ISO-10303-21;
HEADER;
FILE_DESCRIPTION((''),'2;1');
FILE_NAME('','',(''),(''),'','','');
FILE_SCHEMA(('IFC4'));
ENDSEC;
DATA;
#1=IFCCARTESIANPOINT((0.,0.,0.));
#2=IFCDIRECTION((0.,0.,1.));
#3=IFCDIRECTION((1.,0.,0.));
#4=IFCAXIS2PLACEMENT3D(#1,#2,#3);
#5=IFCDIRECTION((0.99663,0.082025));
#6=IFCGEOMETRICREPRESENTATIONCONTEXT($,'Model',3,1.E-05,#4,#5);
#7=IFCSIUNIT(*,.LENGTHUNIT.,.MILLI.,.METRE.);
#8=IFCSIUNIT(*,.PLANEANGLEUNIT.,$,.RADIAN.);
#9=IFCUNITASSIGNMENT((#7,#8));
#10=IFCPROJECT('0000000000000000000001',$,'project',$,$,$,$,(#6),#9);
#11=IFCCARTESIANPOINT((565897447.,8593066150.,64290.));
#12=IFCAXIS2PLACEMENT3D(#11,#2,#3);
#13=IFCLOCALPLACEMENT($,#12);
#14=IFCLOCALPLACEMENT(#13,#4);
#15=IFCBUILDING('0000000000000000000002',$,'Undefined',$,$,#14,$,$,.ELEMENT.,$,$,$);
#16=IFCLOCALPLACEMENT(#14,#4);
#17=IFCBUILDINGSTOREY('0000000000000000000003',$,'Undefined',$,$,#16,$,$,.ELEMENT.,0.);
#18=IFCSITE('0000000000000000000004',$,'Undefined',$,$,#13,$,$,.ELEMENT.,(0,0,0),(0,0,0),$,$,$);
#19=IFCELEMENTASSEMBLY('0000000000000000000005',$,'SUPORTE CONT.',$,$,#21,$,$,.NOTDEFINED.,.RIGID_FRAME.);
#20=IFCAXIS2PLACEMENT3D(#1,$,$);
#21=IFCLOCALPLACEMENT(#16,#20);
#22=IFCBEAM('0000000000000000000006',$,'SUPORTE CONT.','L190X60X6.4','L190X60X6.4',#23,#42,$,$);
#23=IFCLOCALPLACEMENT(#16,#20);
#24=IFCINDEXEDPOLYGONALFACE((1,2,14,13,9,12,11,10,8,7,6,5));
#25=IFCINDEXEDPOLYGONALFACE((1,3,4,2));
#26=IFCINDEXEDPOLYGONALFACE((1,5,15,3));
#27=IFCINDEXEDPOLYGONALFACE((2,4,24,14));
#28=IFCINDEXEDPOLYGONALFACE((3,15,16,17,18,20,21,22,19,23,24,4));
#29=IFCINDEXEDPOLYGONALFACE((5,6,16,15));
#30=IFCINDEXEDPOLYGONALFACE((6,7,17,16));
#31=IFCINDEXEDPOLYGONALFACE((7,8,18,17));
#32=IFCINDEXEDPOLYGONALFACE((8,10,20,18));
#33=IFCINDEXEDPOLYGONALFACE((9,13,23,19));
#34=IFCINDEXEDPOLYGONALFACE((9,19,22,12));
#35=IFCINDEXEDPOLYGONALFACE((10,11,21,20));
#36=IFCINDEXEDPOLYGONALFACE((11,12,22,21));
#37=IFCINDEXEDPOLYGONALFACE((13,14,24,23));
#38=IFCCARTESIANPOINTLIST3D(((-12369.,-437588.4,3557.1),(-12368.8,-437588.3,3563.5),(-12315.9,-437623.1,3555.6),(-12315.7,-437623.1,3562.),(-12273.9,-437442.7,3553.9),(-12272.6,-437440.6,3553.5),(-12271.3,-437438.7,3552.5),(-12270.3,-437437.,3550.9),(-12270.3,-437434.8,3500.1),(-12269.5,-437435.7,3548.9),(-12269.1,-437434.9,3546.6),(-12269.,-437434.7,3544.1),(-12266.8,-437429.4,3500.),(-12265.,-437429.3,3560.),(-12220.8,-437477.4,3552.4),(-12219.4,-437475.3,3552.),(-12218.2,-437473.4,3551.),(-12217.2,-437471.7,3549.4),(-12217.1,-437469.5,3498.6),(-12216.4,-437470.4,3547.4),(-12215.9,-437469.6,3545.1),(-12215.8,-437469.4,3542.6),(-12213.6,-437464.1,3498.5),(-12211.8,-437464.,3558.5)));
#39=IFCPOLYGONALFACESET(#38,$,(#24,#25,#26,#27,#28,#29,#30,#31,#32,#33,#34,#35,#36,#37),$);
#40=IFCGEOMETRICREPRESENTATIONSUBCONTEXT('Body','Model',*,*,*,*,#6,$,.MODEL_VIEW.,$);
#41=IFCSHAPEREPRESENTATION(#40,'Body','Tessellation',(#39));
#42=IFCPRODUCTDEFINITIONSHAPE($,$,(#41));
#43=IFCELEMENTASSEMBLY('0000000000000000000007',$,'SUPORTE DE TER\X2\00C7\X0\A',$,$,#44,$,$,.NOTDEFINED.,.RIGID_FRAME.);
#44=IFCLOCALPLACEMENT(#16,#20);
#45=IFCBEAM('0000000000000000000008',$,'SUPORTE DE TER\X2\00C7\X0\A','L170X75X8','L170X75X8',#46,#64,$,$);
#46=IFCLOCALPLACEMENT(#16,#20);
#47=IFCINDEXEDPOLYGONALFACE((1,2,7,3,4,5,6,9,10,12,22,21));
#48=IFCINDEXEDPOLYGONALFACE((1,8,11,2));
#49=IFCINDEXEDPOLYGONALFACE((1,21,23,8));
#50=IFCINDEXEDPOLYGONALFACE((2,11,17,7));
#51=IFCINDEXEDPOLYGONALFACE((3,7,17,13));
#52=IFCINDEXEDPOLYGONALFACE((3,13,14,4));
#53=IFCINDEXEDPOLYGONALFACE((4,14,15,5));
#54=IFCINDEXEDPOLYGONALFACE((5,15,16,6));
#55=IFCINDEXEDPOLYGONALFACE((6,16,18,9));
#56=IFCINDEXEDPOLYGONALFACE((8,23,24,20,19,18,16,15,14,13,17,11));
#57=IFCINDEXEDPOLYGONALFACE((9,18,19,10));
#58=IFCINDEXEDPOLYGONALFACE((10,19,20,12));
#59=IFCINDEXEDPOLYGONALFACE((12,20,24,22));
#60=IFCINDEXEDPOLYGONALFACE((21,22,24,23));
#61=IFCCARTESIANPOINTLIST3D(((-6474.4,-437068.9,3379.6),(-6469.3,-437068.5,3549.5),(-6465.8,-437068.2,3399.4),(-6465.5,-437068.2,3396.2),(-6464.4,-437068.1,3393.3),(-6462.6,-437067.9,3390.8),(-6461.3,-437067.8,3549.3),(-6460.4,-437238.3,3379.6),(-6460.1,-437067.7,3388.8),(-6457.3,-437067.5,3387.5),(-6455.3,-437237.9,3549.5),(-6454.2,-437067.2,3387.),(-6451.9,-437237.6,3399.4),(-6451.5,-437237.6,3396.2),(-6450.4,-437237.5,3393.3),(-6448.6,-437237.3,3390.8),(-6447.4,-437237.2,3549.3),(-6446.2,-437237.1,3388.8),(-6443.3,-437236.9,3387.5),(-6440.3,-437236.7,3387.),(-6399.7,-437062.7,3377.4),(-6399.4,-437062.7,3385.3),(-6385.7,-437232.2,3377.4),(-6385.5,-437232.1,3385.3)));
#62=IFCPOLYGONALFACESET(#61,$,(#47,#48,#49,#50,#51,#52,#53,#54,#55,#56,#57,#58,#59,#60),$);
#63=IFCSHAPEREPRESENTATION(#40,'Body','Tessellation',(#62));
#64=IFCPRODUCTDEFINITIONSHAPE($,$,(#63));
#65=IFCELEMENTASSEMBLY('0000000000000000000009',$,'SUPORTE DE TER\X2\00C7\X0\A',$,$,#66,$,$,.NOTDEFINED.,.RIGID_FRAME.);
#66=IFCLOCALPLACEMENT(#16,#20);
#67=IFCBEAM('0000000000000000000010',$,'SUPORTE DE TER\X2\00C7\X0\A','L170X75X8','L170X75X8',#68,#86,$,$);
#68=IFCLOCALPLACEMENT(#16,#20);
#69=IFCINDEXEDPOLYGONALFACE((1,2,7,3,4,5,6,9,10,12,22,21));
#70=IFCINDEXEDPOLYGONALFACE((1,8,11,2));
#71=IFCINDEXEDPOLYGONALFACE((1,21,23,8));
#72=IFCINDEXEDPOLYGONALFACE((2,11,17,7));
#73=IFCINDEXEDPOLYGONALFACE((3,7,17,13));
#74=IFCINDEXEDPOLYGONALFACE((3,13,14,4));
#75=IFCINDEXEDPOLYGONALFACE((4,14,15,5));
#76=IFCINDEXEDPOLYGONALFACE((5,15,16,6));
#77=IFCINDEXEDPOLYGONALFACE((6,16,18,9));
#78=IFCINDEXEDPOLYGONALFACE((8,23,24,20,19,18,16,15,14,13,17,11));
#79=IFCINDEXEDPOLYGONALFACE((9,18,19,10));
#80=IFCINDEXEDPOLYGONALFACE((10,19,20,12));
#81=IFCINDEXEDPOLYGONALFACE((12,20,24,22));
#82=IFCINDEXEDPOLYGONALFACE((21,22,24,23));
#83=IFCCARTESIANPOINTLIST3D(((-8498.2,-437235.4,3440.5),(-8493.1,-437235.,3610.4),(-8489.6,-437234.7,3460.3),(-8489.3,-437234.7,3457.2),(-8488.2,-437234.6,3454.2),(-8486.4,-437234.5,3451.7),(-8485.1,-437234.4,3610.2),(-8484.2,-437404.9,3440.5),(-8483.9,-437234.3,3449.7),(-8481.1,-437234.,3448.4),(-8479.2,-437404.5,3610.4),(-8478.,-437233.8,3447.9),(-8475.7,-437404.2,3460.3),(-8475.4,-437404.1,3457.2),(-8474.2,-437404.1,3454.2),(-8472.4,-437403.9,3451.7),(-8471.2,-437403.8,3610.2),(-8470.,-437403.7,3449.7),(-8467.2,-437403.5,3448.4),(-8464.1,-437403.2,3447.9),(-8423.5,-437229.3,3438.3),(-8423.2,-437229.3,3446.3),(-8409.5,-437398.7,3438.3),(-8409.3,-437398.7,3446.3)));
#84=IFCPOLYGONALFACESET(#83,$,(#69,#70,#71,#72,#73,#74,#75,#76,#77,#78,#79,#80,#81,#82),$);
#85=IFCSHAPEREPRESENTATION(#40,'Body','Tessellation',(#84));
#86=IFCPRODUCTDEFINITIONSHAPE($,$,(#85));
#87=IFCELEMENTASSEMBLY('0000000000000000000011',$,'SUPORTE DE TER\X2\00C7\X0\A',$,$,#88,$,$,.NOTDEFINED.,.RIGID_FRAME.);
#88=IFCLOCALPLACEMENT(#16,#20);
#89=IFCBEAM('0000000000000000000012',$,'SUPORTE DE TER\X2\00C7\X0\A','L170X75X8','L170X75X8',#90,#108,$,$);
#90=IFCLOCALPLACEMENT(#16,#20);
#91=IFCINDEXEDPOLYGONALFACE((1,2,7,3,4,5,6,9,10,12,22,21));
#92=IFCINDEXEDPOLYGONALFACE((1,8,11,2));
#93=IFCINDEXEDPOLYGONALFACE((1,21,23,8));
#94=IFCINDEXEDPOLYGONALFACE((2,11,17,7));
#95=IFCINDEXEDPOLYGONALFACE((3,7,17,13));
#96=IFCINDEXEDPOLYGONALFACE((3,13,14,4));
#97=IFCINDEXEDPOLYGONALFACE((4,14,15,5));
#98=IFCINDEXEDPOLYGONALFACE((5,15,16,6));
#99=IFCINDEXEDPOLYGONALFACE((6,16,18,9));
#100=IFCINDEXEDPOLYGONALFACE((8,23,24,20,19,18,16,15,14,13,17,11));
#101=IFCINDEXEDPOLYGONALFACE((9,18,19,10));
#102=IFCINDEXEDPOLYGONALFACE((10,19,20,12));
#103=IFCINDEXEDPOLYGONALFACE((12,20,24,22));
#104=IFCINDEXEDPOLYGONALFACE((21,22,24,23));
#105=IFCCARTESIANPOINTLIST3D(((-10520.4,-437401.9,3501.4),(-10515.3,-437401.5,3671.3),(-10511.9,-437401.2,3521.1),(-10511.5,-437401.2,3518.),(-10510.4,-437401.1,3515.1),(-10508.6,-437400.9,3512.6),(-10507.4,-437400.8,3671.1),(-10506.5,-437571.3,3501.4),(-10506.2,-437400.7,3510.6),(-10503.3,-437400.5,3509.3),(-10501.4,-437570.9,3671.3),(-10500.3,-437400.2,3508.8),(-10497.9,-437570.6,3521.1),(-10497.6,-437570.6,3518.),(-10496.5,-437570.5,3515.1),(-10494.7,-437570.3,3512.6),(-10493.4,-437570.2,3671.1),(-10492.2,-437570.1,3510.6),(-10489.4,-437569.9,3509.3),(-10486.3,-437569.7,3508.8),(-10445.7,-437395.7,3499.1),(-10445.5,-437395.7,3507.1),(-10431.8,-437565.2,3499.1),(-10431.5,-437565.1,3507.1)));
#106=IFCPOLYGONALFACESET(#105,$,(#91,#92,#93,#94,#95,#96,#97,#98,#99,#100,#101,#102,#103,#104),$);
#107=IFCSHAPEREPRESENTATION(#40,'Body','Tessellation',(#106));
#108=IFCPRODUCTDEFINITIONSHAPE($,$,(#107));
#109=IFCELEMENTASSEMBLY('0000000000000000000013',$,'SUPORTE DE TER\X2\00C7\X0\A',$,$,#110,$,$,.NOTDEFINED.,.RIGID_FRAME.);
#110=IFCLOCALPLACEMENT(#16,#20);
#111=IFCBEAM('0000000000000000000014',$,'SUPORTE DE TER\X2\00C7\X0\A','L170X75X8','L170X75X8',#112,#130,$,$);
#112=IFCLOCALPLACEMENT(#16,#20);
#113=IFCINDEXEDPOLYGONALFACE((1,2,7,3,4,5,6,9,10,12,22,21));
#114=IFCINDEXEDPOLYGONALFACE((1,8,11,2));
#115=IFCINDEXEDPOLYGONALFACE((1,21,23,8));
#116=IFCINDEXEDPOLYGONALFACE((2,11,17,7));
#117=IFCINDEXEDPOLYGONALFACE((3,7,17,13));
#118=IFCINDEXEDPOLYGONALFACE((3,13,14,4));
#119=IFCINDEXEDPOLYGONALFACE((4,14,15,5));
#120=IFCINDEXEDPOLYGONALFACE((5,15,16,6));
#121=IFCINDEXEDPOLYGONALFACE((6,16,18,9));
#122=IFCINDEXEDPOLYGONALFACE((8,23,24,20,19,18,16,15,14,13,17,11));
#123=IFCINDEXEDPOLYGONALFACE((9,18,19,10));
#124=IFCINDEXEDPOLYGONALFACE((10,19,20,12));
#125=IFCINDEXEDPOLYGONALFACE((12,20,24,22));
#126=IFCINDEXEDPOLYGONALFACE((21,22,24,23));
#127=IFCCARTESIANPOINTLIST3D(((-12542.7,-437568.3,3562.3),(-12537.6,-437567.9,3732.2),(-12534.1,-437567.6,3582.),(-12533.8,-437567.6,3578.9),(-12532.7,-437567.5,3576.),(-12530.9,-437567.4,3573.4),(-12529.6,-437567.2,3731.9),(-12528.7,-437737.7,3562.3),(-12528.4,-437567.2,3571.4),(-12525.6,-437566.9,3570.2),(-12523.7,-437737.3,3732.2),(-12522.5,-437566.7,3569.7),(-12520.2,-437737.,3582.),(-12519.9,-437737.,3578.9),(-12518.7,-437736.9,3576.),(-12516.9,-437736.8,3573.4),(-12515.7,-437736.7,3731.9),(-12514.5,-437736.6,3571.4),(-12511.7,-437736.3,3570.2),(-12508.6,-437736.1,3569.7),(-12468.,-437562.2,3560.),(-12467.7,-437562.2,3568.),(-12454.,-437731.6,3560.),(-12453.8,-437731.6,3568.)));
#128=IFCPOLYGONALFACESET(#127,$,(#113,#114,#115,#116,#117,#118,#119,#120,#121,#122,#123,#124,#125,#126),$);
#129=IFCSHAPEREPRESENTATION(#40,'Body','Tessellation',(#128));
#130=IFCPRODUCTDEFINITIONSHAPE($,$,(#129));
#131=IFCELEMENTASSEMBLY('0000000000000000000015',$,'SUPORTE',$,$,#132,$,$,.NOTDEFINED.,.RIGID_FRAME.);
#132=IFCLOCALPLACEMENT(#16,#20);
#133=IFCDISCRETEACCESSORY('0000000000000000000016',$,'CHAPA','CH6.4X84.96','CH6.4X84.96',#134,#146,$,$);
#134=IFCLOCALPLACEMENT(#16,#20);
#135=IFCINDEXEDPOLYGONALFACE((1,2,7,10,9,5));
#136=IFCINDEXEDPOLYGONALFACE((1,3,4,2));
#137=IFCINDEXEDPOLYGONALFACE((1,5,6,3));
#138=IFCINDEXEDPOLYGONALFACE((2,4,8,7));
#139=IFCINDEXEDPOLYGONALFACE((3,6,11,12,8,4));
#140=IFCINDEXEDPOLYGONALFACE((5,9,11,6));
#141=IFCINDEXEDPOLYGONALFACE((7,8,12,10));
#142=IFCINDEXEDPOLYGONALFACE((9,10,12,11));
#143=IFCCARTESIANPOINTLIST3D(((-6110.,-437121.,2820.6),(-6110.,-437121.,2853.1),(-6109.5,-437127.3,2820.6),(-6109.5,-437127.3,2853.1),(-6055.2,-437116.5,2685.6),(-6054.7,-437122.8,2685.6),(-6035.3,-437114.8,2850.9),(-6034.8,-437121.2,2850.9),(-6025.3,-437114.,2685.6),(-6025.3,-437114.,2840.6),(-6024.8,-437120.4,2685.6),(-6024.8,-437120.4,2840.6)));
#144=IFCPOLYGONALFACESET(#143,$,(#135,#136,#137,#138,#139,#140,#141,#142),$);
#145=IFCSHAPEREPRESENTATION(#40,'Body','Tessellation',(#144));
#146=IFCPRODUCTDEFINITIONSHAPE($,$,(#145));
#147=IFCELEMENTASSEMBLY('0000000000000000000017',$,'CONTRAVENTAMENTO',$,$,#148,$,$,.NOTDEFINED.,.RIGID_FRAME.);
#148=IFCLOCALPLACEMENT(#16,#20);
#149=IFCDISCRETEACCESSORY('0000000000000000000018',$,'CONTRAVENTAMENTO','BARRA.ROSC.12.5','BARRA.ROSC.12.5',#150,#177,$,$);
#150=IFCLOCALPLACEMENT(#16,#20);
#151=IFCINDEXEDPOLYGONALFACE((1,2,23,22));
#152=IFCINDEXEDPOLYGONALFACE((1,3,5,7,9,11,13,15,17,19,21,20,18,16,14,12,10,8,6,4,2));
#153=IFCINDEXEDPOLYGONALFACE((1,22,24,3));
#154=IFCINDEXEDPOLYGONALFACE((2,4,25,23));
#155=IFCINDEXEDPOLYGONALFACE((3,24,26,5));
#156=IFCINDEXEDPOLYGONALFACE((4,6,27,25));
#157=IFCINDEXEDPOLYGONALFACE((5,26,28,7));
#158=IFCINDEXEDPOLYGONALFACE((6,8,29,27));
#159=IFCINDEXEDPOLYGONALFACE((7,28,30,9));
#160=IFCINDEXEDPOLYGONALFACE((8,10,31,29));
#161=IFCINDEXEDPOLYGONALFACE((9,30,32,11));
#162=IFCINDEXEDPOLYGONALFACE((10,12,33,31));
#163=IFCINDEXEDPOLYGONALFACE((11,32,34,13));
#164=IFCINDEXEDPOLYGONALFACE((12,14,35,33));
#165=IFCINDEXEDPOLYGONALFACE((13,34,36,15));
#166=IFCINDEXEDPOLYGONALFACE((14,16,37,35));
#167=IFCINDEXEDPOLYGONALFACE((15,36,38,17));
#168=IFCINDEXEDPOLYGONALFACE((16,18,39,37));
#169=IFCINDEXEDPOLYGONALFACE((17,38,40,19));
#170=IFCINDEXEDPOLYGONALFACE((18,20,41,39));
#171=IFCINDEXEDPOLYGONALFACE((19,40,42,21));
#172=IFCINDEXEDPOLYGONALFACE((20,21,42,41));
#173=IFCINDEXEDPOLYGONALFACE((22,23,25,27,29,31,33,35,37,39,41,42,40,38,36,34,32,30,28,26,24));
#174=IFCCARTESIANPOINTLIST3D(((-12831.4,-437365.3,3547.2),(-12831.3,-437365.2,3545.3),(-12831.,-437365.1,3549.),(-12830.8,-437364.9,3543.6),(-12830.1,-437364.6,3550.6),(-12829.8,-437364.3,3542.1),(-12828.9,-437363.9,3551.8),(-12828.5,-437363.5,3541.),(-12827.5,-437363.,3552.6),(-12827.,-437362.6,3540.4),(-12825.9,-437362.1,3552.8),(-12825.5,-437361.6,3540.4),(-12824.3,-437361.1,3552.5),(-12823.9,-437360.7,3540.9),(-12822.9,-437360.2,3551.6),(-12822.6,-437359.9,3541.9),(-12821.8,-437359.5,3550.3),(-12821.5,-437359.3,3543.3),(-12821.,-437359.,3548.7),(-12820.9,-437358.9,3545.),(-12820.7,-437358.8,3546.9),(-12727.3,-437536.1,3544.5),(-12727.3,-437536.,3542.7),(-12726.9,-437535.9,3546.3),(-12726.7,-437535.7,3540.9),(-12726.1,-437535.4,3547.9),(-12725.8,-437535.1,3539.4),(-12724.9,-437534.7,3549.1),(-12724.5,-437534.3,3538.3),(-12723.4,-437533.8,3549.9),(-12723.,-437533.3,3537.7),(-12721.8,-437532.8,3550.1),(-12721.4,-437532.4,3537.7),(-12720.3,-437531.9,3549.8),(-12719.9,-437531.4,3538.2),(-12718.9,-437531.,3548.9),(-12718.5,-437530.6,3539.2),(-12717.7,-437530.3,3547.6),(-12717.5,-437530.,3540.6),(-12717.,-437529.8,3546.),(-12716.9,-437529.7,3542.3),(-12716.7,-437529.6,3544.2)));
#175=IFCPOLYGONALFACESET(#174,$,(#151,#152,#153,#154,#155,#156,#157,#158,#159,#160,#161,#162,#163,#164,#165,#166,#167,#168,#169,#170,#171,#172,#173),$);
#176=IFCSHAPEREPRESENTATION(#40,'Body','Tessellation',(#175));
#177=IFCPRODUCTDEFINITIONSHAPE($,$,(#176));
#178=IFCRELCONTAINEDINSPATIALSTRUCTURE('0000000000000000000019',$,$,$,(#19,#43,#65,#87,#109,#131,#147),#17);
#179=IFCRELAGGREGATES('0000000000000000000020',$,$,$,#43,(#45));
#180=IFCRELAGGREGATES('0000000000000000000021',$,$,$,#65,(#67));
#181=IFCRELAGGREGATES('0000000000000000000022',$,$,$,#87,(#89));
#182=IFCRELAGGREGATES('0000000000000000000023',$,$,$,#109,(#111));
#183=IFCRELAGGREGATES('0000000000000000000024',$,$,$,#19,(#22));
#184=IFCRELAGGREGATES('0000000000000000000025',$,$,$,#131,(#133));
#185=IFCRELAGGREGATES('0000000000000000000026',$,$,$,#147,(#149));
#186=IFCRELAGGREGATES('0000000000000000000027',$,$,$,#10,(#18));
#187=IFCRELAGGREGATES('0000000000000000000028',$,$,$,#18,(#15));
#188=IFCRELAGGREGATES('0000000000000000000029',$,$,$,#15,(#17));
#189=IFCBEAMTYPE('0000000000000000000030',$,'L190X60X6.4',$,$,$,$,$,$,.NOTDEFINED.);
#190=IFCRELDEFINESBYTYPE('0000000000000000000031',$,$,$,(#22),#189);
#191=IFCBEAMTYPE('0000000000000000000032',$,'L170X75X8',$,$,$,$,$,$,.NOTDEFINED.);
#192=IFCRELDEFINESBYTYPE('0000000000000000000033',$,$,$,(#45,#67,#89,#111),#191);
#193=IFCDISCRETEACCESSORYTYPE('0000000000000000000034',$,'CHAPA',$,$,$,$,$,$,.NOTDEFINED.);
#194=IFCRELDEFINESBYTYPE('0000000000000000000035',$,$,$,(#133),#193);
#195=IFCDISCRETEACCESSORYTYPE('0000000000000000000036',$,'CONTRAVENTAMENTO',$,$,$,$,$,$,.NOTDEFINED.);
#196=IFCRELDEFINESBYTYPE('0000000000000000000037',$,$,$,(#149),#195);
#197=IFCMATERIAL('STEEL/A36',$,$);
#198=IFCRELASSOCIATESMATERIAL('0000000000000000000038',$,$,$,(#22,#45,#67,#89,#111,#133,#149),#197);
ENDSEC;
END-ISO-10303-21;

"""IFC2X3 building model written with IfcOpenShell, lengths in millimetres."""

from ifc_helpers import new_model, si_unit, direction, frame, origin_with_axes, origin_2d_with_axis, place, context, subcontext, project, spatial, polyline, circle, l_section, outline, extrude, material, type_object, element, aggregate, save


model = new_model("IFC2X3")

# Units and contexts
model_context = context("Model", 3, precision=1e-05, world=origin_with_axes(), true_north=direction((0.99663, 0.082025)))
body_context = subcontext(model_context, "Body", "Model", "MODEL_VIEW")
ifc_project = project(units=[si_unit("LENGTHUNIT", "METRE", prefix="MILLI"), si_unit("PLANEANGLEUNIT", "RADIAN")], contexts=[model_context])

# Site, building, storey
site_placement = place(None, frame((565897447.0, 8593066150.0, 64290.0), z_axis=(0.0, 0.0, 1.0), x_axis=(1.0, 0.0, 0.0)))
site = spatial("IfcSite", under=ifc_project, at=site_placement, Name="Undefined", CompositionType="ELEMENT", RefLatitude=(0, 0, 0), RefLongitude=(0, 0, 0))
building_placement = place(site_placement, origin_with_axes())
building = spatial("IfcBuilding", under=site, at=building_placement, Name="Undefined", CompositionType="ELEMENT")
storey_placement = place(building_placement, origin_with_axes())
storey = spatial("IfcBuildingStorey", under=building, at=storey_placement, Name="Undefined", CompositionType="ELEMENT", Elevation=0.0)

# Element assemblies, beams
ifc_material_1 = material(Name="STEEL/A36")
beam_type_1 = type_object("IfcBeamType", Name="L190X60X6.4", PredefinedType="NOTDEFINED")
assembly_1_placement = place(storey_placement, origin_with_axes())
assembly_1 = element("IfcElementAssembly", 1, at=assembly_1_placement, inside=storey, Name="SUPORTE CONT.", AssemblyPlace="NOTDEFINED", PredefinedType="RIGID_FRAME")
beam_1_placement = place(assembly_1_placement, frame((-12317.8, -437508.9, 3531.7), z_axis=(-0.546411, -0.837315, 0.018398), x_axis=(0.836984, -0.546715, -0.02368)))
beam_1 = element("IfcBeam", 2, at=beam_1_placement, type_object=beam_type_1, material=ifc_material_1, Name="SUPORTE CONT.", Description="L190X60X6.4", ObjectType="L190X60X6.4", context=body_context, shape_type="SweptSolid", body=[
    extrude(l_section(Depth=190.0, Width=60.0, Thickness=6.4, FilletRadius=9.6, at=origin_2d_with_axis()), frame((63.5, 0.0, 0.0), z_axis=(-1.0, 0.0, 0.0), x_axis=(0.0, -1.0, 0.0)), (0.0, 0.0, 1.0), 63.5),
])
assembly_2_placement = place(storey_placement, origin_with_axes())
assembly_2 = element("IfcElementAssembly", 3, at=assembly_2_placement, inside=storey, Name="SUPORTE DE TERÇA", AssemblyPlace="NOTDEFINED", PredefinedType="RIGID_FRAME")
beam_type_2 = type_object("IfcBeamType", Name="L170X75X8", PredefinedType="NOTDEFINED")
beam_2_placement = place(assembly_2_placement, frame((-6420.5, -437235.0, 3463.4), z_axis=(0.029885, 0.00246, 0.99955), x_axis=(-0.082025, 0.99663, 0.0)))
beam_2 = element("IfcBeam", 4, at=beam_2_placement, type_object=beam_type_2, material=ifc_material_1, Name="SUPORTE DE TERÇA", Description="L170X75X8", ObjectType="L170X75X8", context=body_context, shape_type="SweptSolid", body=[
    extrude(l_section(Depth=170.0, Width=75.0, Thickness=8.0, FilletRadius=12.0, at=origin_2d_with_axis()), frame((170.0, 0.0, 0.0), z_axis=(-1.0, 0.0, 0.0), x_axis=(0.0, -1.0, 0.0)), (0.0, 0.0, 1.0), 170.0),
])
aggregate(assembly_2, [beam_2])
assembly_3_placement = place(storey_placement, origin_with_axes())
assembly_3 = element("IfcElementAssembly", 5, at=assembly_3_placement, inside=storey, Name="SUPORTE DE TERÇA", AssemblyPlace="NOTDEFINED", PredefinedType="RIGID_FRAME")
beam_3_placement = place(assembly_3_placement, frame((-8444.3, -437401.6, 3524.4), z_axis=(0.029885, 0.00246, 0.99955), x_axis=(-0.082025, 0.99663, 0.0)))
beam_3 = element("IfcBeam", 6, at=beam_3_placement, type_object=beam_type_2, material=ifc_material_1, Name="SUPORTE DE TERÇA", Description="L170X75X8", ObjectType="L170X75X8", context=body_context, shape_type="SweptSolid", body=[
    extrude(l_section(Depth=170.0, Width=75.0, Thickness=8.0, FilletRadius=12.0, at=origin_2d_with_axis()), frame((170.0, 0.0, 0.0), z_axis=(-1.0, 0.0, 0.0), x_axis=(0.0, -1.0, 0.0)), (0.0, 0.0, 1.0), 170.0),
])
aggregate(assembly_3, [beam_3])
assembly_4_placement = place(storey_placement, origin_with_axes())
assembly_4 = element("IfcElementAssembly", 7, at=assembly_4_placement, inside=storey, Name="SUPORTE DE TERÇA", AssemblyPlace="NOTDEFINED", PredefinedType="RIGID_FRAME")
beam_4_placement = place(assembly_4_placement, frame((-10466.6, -437568.0, 3585.2), z_axis=(0.029885, 0.00246, 0.99955), x_axis=(-0.082025, 0.99663, 0.0)))
beam_4 = element("IfcBeam", 8, at=beam_4_placement, type_object=beam_type_2, material=ifc_material_1, Name="SUPORTE DE TERÇA", Description="L170X75X8", ObjectType="L170X75X8", context=body_context, shape_type="SweptSolid", body=[
    extrude(l_section(Depth=170.0, Width=75.0, Thickness=8.0, FilletRadius=12.0, at=origin_2d_with_axis()), frame((170.0, 0.0, 0.0), z_axis=(-1.0, 0.0, 0.0), x_axis=(0.0, -1.0, 0.0)), (0.0, 0.0, 1.0), 170.0),
])
aggregate(assembly_4, [beam_4])
assembly_5_placement = place(storey_placement, origin_with_axes())
assembly_5 = element("IfcElementAssembly", 9, at=assembly_5_placement, inside=storey, Name="SUPORTE DE TERÇA", AssemblyPlace="NOTDEFINED", PredefinedType="RIGID_FRAME")
beam_5_placement = place(assembly_5_placement, frame((-12488.8, -437734.5, 3646.1), z_axis=(0.029885, 0.00246, 0.99955), x_axis=(-0.082025, 0.99663, 0.0)))
beam_5 = element("IfcBeam", 10, at=beam_5_placement, type_object=beam_type_2, material=ifc_material_1, Name="SUPORTE DE TERÇA", Description="L170X75X8", ObjectType="L170X75X8", context=body_context, shape_type="SweptSolid", body=[
    extrude(l_section(Depth=170.0, Width=75.0, Thickness=8.0, FilletRadius=12.0, at=origin_2d_with_axis()), frame((170.0, 0.0, 0.0), z_axis=(-1.0, 0.0, 0.0), x_axis=(0.0, -1.0, 0.0)), (0.0, 0.0, 1.0), 170.0),
])
aggregate(assembly_5, [beam_5])

# Shared definitions
discrete_accessory_type_1 = type_object("IfcDiscreteAccessoryType", Name="CHAPA")
aggregate(assembly_1, [beam_1])

# Element assemblies, discrete accessories
assembly_6_placement = place(storey_placement, origin_with_axes())
assembly_6 = element("IfcElementAssembly", 11, at=assembly_6_placement, inside=storey, Name="SUPORTE", AssemblyPlace="NOTDEFINED", PredefinedType="RIGID_FRAME")
discrete_accessory_1_placement = place(assembly_6_placement, frame((-6025.1, -437117.2, 2850.6), z_axis=(-0.082025, 0.99663, 0.0), x_axis=(0.0, 0.0, -1.0)))
discrete_accessory_1 = element("IfcDiscreteAccessory", 12, at=discrete_accessory_1_placement, type_object=discrete_accessory_type_1, material=ifc_material_1, Name="CHAPA", Description="CH6.4X84.96", ObjectType="CH6.4X84.96", context=body_context, shape_type="SweptSolid", body=[
    extrude(outline(polyline([(-0.3, 10.0), (10.0, 0.0), (165.0, 0.0), (165.0, 30.0), (30.0, 85.0), (-2.5, 85.0), (-0.3, 10.0)])), frame((0.0, 0.0, -3.2), z_axis=(0.0, 0.0, 1.0), x_axis=(1.0, 0.0, 0.0)), (0.0, 0.0, 1.0), 6.4),
])
aggregate(assembly_6, [discrete_accessory_1])
assembly_7_placement = place(storey_placement, origin_with_axes())
assembly_7 = element("IfcElementAssembly", 13, at=assembly_7_placement, inside=storey, Name="CONTRAVENTAMENTO", AssemblyPlace="NOTDEFINED", PredefinedType="RIGID_FRAME")
discrete_accessory_type_2 = type_object("IfcDiscreteAccessoryType", Name="CONTRAVENTAMENTO")
discrete_accessory_2_placement = place(assembly_7_placement, frame((-12722.0, -437532.8, 3543.9), z_axis=(-0.853486, -0.520426, 0.026799), x_axis=(-0.520257, 0.853903, 0.013454)))
discrete_accessory_2 = element("IfcDiscreteAccessory", 14, at=discrete_accessory_2_placement, type_object=discrete_accessory_type_2, material=ifc_material_1, Name="CONTRAVENTAMENTO", Description="BARRA.ROSC.12.5", ObjectType="BARRA.ROSC.12.5", context=body_context, shape_type="SweptSolid", body=[
    extrude(circle(Radius=6.2, at=origin_2d_with_axis()), frame((200.0, 0.0, 0.0), z_axis=(-1.0, 0.0, 0.0), x_axis=(0.0, -1.0, 0.0)), (0.0, 0.0, 1.0), 200.0),
])
aggregate(assembly_7, [discrete_accessory_2])

save(model, "model.ifc")
